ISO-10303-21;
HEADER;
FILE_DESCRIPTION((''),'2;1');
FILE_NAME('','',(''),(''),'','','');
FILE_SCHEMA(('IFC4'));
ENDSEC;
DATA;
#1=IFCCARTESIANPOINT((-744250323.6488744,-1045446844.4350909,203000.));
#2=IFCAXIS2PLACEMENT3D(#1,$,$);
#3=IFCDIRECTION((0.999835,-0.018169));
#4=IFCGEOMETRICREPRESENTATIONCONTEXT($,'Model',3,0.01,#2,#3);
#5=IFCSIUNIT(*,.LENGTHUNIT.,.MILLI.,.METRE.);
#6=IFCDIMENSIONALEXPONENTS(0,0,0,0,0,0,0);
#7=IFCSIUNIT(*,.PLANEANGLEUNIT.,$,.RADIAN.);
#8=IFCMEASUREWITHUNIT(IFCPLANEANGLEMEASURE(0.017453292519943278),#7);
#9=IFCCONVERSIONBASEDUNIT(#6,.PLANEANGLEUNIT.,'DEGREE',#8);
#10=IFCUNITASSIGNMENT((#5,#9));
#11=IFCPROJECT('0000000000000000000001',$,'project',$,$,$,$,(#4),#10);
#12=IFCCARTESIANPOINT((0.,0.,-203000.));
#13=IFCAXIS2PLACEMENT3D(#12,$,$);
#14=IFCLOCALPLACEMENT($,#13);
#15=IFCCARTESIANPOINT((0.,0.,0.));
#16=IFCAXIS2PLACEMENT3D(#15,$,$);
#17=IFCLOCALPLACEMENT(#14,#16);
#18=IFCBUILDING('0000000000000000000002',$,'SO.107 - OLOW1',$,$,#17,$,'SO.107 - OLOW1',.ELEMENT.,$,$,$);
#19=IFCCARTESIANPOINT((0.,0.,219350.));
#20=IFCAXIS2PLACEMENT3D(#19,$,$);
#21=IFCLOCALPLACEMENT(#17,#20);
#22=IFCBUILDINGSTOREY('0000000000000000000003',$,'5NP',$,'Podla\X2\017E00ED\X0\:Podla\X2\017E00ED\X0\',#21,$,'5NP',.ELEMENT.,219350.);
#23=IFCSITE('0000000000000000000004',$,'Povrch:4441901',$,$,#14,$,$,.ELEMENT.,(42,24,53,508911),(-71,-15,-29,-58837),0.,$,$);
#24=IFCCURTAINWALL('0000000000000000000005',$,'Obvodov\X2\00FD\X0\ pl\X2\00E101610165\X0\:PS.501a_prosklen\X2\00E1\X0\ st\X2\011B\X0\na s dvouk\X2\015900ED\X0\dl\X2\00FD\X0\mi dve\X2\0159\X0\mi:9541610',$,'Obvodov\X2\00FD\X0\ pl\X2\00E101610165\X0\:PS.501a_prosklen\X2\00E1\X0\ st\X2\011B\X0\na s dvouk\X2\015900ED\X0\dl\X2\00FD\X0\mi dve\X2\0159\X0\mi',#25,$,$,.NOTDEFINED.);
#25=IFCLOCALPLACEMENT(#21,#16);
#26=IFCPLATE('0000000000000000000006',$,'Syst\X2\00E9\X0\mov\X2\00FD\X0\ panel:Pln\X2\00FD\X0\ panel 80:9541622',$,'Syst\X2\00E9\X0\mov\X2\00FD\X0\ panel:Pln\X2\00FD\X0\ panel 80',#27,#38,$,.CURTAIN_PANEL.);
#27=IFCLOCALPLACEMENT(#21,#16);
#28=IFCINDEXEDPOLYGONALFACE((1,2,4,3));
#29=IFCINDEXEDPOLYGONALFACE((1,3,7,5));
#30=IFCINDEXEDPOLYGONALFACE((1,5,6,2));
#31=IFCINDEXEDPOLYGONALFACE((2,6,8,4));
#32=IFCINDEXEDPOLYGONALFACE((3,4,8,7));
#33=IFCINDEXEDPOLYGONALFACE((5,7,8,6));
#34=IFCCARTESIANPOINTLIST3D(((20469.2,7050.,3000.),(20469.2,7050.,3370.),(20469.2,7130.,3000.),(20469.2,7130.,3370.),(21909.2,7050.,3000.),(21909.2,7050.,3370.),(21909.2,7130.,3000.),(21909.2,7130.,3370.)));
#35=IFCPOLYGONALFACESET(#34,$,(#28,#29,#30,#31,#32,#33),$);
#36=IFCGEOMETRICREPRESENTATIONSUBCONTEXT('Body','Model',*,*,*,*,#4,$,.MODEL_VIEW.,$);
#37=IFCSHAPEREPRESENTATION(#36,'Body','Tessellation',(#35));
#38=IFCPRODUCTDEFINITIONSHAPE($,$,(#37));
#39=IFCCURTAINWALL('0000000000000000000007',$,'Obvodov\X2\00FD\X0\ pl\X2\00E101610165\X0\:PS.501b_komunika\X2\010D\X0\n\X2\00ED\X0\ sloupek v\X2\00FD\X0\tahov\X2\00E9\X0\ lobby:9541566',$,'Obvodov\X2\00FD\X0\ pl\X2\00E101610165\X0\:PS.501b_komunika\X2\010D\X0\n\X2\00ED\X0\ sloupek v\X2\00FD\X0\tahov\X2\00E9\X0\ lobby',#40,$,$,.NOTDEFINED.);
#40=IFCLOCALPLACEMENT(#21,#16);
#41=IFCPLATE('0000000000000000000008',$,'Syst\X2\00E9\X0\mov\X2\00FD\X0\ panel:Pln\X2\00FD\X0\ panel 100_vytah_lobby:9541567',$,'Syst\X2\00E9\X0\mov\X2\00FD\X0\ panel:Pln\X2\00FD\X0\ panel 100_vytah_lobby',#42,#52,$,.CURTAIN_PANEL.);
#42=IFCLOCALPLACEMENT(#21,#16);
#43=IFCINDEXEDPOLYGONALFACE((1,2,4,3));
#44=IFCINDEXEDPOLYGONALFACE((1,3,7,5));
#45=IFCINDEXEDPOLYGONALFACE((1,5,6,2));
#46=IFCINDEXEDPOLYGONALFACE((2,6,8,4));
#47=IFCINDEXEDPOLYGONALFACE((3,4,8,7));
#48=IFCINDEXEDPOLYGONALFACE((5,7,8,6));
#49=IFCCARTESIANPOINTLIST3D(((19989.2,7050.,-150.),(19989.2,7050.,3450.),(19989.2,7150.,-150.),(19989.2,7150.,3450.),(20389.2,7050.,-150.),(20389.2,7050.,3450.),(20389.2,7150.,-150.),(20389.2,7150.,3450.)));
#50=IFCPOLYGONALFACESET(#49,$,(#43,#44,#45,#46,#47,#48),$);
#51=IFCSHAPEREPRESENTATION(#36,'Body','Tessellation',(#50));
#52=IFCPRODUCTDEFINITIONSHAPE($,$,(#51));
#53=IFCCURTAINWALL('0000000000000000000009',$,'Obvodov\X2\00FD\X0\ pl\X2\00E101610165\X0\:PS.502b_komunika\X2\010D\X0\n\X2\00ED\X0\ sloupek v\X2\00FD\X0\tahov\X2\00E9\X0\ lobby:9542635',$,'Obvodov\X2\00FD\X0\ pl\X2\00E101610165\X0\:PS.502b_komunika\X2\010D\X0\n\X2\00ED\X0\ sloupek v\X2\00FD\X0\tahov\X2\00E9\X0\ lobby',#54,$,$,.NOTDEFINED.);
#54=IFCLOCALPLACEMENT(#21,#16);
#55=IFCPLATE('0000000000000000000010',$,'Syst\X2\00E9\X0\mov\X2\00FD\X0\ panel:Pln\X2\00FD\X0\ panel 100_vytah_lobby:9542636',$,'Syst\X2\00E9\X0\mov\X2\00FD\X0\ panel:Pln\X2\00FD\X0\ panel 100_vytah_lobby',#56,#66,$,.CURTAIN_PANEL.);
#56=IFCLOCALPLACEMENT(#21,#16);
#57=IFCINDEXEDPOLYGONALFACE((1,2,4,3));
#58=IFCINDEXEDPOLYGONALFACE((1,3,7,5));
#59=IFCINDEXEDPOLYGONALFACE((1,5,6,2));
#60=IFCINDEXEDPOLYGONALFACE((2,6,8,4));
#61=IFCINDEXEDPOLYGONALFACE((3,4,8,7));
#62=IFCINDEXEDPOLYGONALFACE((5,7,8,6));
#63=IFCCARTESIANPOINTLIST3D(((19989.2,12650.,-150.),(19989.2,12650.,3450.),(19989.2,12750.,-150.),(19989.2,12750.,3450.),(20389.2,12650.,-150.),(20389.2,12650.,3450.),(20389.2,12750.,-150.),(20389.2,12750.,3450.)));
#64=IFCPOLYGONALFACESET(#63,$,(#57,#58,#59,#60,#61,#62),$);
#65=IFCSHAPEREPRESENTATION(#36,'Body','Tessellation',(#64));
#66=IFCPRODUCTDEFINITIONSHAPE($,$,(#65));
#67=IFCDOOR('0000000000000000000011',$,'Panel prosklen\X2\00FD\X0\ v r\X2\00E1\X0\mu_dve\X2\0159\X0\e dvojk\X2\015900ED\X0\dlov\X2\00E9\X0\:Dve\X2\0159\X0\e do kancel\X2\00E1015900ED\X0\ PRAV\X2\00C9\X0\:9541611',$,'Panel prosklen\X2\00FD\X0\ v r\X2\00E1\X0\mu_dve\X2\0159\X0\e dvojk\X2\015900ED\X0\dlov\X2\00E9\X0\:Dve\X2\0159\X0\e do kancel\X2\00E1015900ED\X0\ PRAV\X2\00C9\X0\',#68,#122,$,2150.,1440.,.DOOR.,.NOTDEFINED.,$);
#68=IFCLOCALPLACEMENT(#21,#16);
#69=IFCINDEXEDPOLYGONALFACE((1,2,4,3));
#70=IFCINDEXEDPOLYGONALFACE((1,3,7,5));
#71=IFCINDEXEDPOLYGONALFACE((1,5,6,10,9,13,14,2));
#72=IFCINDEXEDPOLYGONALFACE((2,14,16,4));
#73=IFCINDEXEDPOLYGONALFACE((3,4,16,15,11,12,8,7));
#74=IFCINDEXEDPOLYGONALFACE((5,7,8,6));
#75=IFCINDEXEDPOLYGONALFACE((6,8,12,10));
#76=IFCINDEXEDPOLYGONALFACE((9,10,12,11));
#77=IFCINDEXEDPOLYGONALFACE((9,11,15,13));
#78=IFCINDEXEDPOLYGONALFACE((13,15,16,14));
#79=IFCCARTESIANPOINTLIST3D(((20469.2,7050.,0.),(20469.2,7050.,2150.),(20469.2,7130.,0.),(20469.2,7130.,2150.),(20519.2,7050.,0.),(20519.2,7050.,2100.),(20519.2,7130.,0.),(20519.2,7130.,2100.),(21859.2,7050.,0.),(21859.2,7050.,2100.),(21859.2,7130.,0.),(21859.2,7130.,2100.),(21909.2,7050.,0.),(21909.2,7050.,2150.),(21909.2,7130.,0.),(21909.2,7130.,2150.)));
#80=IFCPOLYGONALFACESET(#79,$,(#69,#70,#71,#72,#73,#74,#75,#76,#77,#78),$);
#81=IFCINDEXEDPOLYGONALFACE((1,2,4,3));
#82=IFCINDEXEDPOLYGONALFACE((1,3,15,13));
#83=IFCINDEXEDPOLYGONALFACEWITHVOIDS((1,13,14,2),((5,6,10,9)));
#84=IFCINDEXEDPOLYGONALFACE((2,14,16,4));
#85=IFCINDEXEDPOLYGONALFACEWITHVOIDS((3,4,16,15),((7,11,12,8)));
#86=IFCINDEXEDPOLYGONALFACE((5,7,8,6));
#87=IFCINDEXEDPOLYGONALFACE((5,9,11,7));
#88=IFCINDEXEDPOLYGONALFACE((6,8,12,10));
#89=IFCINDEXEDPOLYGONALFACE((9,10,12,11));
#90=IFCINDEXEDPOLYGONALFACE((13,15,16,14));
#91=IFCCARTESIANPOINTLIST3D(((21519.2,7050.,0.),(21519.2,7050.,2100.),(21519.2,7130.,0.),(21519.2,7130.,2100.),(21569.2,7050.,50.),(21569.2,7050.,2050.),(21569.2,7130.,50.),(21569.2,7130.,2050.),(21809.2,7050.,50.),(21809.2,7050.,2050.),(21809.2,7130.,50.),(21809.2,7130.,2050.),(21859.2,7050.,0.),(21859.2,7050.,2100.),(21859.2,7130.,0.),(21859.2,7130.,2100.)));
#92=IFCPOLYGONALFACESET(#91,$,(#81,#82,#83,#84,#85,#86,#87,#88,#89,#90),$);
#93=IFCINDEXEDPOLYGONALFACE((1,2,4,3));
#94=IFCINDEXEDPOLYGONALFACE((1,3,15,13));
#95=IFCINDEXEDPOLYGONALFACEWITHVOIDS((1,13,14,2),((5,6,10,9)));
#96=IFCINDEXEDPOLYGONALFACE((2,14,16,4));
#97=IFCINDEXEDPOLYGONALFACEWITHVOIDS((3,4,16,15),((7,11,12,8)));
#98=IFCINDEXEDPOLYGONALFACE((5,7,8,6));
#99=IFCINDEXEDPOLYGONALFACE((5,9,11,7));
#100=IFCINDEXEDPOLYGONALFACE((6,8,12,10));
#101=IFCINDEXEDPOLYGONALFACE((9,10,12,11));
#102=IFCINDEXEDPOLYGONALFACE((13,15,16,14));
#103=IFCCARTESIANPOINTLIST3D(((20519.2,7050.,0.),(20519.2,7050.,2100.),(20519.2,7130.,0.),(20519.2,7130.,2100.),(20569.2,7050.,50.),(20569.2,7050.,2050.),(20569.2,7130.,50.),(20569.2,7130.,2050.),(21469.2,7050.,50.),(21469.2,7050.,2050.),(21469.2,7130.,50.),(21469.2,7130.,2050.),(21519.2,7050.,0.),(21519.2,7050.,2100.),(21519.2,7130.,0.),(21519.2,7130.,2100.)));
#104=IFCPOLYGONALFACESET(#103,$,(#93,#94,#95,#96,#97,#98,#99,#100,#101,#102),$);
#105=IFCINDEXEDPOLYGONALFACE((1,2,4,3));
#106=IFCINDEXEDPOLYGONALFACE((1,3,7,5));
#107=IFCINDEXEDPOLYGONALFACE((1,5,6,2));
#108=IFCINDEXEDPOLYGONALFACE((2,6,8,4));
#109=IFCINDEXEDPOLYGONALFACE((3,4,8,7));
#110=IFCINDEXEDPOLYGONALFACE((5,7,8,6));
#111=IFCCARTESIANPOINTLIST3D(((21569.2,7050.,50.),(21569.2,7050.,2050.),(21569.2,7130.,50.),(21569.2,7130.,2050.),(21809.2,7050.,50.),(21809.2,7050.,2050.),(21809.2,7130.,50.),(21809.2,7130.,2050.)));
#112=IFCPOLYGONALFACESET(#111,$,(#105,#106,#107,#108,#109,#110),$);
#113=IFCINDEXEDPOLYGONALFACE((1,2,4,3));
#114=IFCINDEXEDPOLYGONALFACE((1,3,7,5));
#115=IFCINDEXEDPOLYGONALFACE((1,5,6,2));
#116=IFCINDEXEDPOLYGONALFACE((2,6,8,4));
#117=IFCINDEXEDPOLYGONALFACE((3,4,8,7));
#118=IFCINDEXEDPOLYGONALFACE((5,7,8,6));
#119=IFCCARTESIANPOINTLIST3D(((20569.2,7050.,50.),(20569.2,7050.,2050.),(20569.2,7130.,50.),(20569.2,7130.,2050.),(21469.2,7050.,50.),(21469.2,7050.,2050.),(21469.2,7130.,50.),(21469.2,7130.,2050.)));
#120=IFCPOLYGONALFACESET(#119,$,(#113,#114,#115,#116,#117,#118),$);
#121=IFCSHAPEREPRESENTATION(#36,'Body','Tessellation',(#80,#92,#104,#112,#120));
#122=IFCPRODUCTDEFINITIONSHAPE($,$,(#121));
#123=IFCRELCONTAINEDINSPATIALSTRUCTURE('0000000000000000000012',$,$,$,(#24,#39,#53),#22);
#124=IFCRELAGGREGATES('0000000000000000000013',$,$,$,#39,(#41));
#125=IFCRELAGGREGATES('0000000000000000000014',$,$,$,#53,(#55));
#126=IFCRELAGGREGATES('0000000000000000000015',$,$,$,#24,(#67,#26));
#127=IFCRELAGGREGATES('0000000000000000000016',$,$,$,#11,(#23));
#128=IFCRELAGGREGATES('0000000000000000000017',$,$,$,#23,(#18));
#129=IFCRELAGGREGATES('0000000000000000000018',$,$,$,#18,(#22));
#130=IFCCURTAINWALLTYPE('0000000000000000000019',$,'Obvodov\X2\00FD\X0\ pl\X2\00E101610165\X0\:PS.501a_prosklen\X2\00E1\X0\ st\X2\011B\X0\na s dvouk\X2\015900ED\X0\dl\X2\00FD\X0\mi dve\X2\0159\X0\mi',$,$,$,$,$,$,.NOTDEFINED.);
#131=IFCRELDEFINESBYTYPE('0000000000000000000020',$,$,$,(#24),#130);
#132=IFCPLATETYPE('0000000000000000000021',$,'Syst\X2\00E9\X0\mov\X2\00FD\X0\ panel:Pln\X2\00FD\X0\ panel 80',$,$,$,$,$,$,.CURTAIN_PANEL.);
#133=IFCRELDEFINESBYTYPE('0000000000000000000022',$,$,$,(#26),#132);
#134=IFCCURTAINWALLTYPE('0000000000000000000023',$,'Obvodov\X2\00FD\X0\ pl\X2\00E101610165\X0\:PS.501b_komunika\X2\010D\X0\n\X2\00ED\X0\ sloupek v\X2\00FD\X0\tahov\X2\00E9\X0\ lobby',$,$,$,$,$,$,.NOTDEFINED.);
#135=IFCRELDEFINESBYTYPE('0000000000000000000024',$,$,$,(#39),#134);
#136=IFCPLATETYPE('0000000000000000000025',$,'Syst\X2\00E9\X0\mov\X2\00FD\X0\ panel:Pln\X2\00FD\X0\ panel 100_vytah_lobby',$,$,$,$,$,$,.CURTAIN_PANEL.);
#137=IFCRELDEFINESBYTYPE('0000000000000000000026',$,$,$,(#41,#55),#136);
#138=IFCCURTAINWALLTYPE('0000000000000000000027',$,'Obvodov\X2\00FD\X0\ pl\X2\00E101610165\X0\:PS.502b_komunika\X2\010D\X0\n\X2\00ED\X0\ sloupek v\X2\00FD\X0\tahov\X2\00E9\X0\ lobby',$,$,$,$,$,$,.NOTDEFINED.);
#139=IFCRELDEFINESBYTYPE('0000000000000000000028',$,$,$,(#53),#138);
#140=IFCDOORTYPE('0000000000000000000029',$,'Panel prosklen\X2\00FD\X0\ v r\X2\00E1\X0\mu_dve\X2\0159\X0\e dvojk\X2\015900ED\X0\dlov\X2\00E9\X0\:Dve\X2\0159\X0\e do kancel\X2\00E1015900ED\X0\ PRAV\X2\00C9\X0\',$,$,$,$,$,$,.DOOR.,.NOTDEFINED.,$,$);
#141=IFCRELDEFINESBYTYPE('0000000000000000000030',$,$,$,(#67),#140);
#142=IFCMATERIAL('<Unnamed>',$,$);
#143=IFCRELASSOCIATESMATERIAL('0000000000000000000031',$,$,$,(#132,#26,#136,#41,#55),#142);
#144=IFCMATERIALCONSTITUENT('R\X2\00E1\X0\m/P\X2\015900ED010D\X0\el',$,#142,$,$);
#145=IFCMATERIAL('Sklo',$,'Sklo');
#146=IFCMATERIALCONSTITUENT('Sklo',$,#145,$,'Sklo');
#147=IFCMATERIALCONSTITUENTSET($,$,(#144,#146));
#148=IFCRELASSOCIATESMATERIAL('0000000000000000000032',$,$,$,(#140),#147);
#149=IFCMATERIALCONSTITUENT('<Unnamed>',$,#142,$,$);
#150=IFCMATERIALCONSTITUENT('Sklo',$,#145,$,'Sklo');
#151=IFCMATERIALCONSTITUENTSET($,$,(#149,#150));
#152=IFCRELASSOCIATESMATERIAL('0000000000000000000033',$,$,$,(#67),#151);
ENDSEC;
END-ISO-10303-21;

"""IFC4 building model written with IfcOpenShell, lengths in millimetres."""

from ifc_helpers import new_model, entity, si_unit, converted_unit, direction, frame, origin, place, context, subcontext, project, spatial, indexed_curve, outline, extrude, source, transform, mapped, material, constituent, constituent_set, type_object, type_shapes, element, aggregate, save


model = new_model("IFC4")

# Units and contexts
model_context = context("Model", 3, precision=0.01, world=frame((-744250323.6488744, -1045446844.4350909, 203000.0)), true_north=direction((0.999835, -0.018169)))
body_context = subcontext(model_context, "Body", "Model", "MODEL_VIEW")
ifc_project = project(units=[si_unit("LENGTHUNIT", "METRE", prefix="MILLI"), converted_unit("PLANEANGLEUNIT", "DEGREE", entity("IfcPlaneAngleMeasure", 0.017453292519943278), si_unit("PLANEANGLEUNIT", "RADIAN"), dimensions=[0, 0, 0, 0, 0, 0, 0])], contexts=[model_context])

# Site, building, storey
site_placement = place(None, frame((0.0, 0.0, -203000.0)))
site = spatial("IfcSite", under=ifc_project, at=site_placement, Name="Povrch:4441901", CompositionType="ELEMENT", RefLatitude=(42, 24, 53, 508911), RefLongitude=(-71, -15, -29, -58837), RefElevation=0.0)
building_placement = place(site_placement, origin())
building = spatial("IfcBuilding", under=site, at=building_placement, Name="SO.107 - OLOW1", LongName="SO.107 - OLOW1", CompositionType="ELEMENT")
storey_placement = place(building_placement, frame((0.0, 0.0, 219350.0)))
storey = spatial("IfcBuildingStorey", under=building, at=storey_placement, Name="5NP", ObjectType="Podlaží:Podlaží", LongName="5NP", CompositionType="ELEMENT", Elevation=219350.0)

# Curtain wall
ifc_material_1 = material(Name="<Unnamed>")
curtain_wall_type_1 = type_object("IfcCurtainWallType", Name="Obvodový plášť:PS.501a_prosklená stěna s dvoukřídlými dveřmi", PredefinedType="NOTDEFINED")
curtain_wall_1_placement = place(storey_placement, frame((0.0, 0.0, -219350.0)))
curtain_wall_1 = element("IfcCurtainWall", 1, at=curtain_wall_1_placement, inside=storey, type_object=curtain_wall_type_1, Name="Obvodový plášť:PS.501a_prosklená stěna s dvoukřídlými dveřmi:9541610", ObjectType="Obvodový plášť:PS.501a_prosklená stěna s dvoukřídlými dveřmi", PredefinedType="NOTDEFINED")

# Plate
ifc_material_2 = material(Name="Sklo", Category="Sklo")
plate_type_1 = type_object("IfcPlateType", Name="Systémový panel:Plný panel 80", PredefinedType="CURTAIN_PANEL", material=ifc_material_1)
shared_shape_1 = source(origin(), body_context, "Body", "SweptSolid", [
    extrude(outline(indexed_curve([(-40.0, -720.0), (40.0, -720.0), (40.0, 720.0), (-40.0, 720.0), (-40.0, -720.0)], self_intersect=False)), frame((0.0, 0.0, 0.0), z_axis=(0.0, 0.0, 1.0), x_axis=(0.0, 1.0, 0.0)), (0.0, 0.0, 1.0), 370.0),
])
type_shapes(plate_type_1, [shared_shape_1])
plate_1_placement = place(curtain_wall_1_placement, frame((21189.2, 7090.0, 222350.0)))
plate_1 = element("IfcPlate", 2, at=plate_1_placement, type_object=plate_type_1, material=ifc_material_1, Name="Systémový panel:Plný panel 80:9541622", ObjectType="Systémový panel:Plný panel 80", PredefinedType="CURTAIN_PANEL", context=body_context, shape_type="MappedRepresentation", body=[
    mapped(shared_shape_1, transform((0.0, 0.0, 0.0), scale=1.0)),
])

# Curtain walls, plates
curtain_wall_type_2 = type_object("IfcCurtainWallType", Name="Obvodový plášť:PS.501b_komunikační sloupek výtahové lobby", PredefinedType="NOTDEFINED")
curtain_wall_2_placement = place(storey_placement, frame((0.0, 0.0, -219350.0)))
curtain_wall_2 = element("IfcCurtainWall", 3, at=curtain_wall_2_placement, inside=storey, type_object=curtain_wall_type_2, Name="Obvodový plášť:PS.501b_komunikační sloupek výtahové lobby:9541566", ObjectType="Obvodový plášť:PS.501b_komunikační sloupek výtahové lobby", PredefinedType="NOTDEFINED")
plate_type_2 = type_object("IfcPlateType", Name="Systémový panel:Plný panel 100_vytah_lobby", PredefinedType="CURTAIN_PANEL", material=ifc_material_1)
shared_shape_2 = source(origin(), body_context, "Body", "SweptSolid", [
    extrude(outline(indexed_curve([(-50.0, -200.0), (50.0, -200.0), (50.0, 200.0), (-50.0, 200.0), (-50.0, -200.0)], self_intersect=False)), frame((0.0, 10.0, 0.0), z_axis=(0.0, 0.0, 1.0), x_axis=(0.0, 1.0, 0.0)), (0.0, 0.0, 1.0), 3600.0),
])
type_shapes(plate_type_2, [shared_shape_2])
plate_2_placement = place(curtain_wall_2_placement, frame((20189.2, 7090.0, 219200.0)))
plate_2 = element("IfcPlate", 4, at=plate_2_placement, type_object=plate_type_2, material=ifc_material_1, Name="Systémový panel:Plný panel 100_vytah_lobby:9541567", ObjectType="Systémový panel:Plný panel 100_vytah_lobby", PredefinedType="CURTAIN_PANEL", context=body_context, shape_type="MappedRepresentation", body=[
    mapped(shared_shape_2, transform((0.0, 0.0, 0.0), scale=1.0)),
])
aggregate(curtain_wall_2, [plate_2])
curtain_wall_type_3 = type_object("IfcCurtainWallType", Name="Obvodový plášť:PS.502b_komunikační sloupek výtahové lobby", PredefinedType="NOTDEFINED")
curtain_wall_3_placement = place(storey_placement, frame((0.0, 0.0, -219350.0)))
curtain_wall_3 = element("IfcCurtainWall", 5, at=curtain_wall_3_placement, inside=storey, type_object=curtain_wall_type_3, Name="Obvodový plášť:PS.502b_komunikační sloupek výtahové lobby:9542635", ObjectType="Obvodový plášť:PS.502b_komunikační sloupek výtahové lobby", PredefinedType="NOTDEFINED")
plate_3_placement = place(curtain_wall_3_placement, frame((20189.2, 12690.0, 219200.0)))
plate_3 = element("IfcPlate", 6, at=plate_3_placement, type_object=plate_type_2, material=ifc_material_1, Name="Systémový panel:Plný panel 100_vytah_lobby:9542636", ObjectType="Systémový panel:Plný panel 100_vytah_lobby", PredefinedType="CURTAIN_PANEL", context=body_context, shape_type="MappedRepresentation", body=[
    mapped(shared_shape_2, transform((0.0, 0.0, 0.0), scale=1.0)),
])
aggregate(curtain_wall_3, [plate_3])

# Door
ifc_constituent_1 = constituent(ifc_material_1, Name="<Unnamed>")
ifc_constituent_2 = constituent(ifc_material_2, Name="Sklo", Category="Sklo")
ifc_constituent_set_1 = constituent_set(constituents=[ifc_constituent_1, ifc_constituent_2])
ifc_constituent_3 = constituent(ifc_material_1, Name="Rám/Příčel")
ifc_constituent_4 = constituent(ifc_material_2, Name="Sklo", Category="Sklo")
ifc_constituent_set_2 = constituent_set(constituents=[ifc_constituent_3, ifc_constituent_4])
door_type = type_object("IfcDoorType", Name="Panel prosklený v rámu_dveře dvojkřídlové:Dveře do kanceláří PRAVÉ", OperationType="NOTDEFINED", PredefinedType="DOOR", material=ifc_constituent_set_2)
shared_shape_3 = source(origin(), body_context, "Body", "SweptSolid", [
    extrude(outline(indexed_curve([(-720.0, -1087.5), (720.0, -1087.5), (720.0, 1062.5), (670.0, 1062.5), (670.0, -1037.5), (-670.0, -1037.5), (-670.0, 1062.5), (-720.0, 1062.5), (-720.0, -1087.5)], self_intersect=False)), frame((0.0, 40.0, 1062.5), z_axis=(0.0, -1.0, 0.0), x_axis=(-1.0, 0.0, 0.0)), (0.0, 0.0, 1.0), 80.0),
    extrude(outline(indexed_curve([(-1050.0, -170.0), (1050.0, -170.0), (1050.0, 170.0), (-1050.0, 170.0), (-1050.0, -170.0)], self_intersect=False), holes=[indexed_curve([(-1000.0, -120.0), (-1000.0, 120.0), (1000.0, 120.0), (1000.0, -120.0), (-1000.0, -120.0)], self_intersect=False)]), frame((-500.0, 40.0, 1050.0), z_axis=(0.0, -1.0, 0.0), x_axis=(0.0, 0.0, -1.0)), (0.0, 0.0, 1.0), 80.0),
    extrude(outline(indexed_curve([(-1050.0, -500.0), (1050.0, -500.0), (1050.0, 500.0), (-1050.0, 500.0), (-1050.0, -500.0)], self_intersect=False), holes=[indexed_curve([(-1000.0, -450.0), (-1000.0, 450.0), (1000.0, 450.0), (1000.0, -450.0), (-1000.0, -450.0)], self_intersect=False)]), frame((170.0, 40.0, 1050.0), z_axis=(0.0, -1.0, 0.0), x_axis=(0.0, 0.0, -1.0)), (0.0, 0.0, 1.0), 80.0),
    extrude(outline(indexed_curve([(-120.0, -40.0), (120.0, -40.0), (120.0, 40.0), (-120.0, 40.0), (-120.0, -40.0)], self_intersect=False)), frame((-500.0, 0.0, 50.0)), (0.0, 0.0, 1.0), 2000.0),
    extrude(outline(indexed_curve([(-450.0, -40.0), (450.0, -40.0), (450.0, 40.0), (-450.0, 40.0), (-450.0, -40.0)], self_intersect=False)), frame((170.0, 0.0, 50.0)), (0.0, 0.0, 1.0), 2000.0),
])
type_shapes(door_type, [shared_shape_3])
door_placement = place(curtain_wall_1_placement, frame((21189.2, 7090.0, 219350.0), z_axis=(0.0, 0.0, 1.0), x_axis=(-1.0, 0.0, 0.0)))
door = element("IfcDoor", 7, at=door_placement, type_object=door_type, material=ifc_constituent_set_1, Name="Panel prosklený v rámu_dveře dvojkřídlové:Dveře do kanceláří PRAVÉ:9541611", ObjectType="Panel prosklený v rámu_dveře dvojkřídlové:Dveře do kanceláří PRAVÉ", OperationType="NOTDEFINED", OverallHeight=2150.0, OverallWidth=1440.0, PredefinedType="DOOR", context=body_context, shape_type="MappedRepresentation", body=[
    mapped(shared_shape_3, transform((0.0, 0.0, 0.0), scale=1.0)),
])
aggregate(curtain_wall_1, [door, plate_1])

save(model, "model.ifc")
